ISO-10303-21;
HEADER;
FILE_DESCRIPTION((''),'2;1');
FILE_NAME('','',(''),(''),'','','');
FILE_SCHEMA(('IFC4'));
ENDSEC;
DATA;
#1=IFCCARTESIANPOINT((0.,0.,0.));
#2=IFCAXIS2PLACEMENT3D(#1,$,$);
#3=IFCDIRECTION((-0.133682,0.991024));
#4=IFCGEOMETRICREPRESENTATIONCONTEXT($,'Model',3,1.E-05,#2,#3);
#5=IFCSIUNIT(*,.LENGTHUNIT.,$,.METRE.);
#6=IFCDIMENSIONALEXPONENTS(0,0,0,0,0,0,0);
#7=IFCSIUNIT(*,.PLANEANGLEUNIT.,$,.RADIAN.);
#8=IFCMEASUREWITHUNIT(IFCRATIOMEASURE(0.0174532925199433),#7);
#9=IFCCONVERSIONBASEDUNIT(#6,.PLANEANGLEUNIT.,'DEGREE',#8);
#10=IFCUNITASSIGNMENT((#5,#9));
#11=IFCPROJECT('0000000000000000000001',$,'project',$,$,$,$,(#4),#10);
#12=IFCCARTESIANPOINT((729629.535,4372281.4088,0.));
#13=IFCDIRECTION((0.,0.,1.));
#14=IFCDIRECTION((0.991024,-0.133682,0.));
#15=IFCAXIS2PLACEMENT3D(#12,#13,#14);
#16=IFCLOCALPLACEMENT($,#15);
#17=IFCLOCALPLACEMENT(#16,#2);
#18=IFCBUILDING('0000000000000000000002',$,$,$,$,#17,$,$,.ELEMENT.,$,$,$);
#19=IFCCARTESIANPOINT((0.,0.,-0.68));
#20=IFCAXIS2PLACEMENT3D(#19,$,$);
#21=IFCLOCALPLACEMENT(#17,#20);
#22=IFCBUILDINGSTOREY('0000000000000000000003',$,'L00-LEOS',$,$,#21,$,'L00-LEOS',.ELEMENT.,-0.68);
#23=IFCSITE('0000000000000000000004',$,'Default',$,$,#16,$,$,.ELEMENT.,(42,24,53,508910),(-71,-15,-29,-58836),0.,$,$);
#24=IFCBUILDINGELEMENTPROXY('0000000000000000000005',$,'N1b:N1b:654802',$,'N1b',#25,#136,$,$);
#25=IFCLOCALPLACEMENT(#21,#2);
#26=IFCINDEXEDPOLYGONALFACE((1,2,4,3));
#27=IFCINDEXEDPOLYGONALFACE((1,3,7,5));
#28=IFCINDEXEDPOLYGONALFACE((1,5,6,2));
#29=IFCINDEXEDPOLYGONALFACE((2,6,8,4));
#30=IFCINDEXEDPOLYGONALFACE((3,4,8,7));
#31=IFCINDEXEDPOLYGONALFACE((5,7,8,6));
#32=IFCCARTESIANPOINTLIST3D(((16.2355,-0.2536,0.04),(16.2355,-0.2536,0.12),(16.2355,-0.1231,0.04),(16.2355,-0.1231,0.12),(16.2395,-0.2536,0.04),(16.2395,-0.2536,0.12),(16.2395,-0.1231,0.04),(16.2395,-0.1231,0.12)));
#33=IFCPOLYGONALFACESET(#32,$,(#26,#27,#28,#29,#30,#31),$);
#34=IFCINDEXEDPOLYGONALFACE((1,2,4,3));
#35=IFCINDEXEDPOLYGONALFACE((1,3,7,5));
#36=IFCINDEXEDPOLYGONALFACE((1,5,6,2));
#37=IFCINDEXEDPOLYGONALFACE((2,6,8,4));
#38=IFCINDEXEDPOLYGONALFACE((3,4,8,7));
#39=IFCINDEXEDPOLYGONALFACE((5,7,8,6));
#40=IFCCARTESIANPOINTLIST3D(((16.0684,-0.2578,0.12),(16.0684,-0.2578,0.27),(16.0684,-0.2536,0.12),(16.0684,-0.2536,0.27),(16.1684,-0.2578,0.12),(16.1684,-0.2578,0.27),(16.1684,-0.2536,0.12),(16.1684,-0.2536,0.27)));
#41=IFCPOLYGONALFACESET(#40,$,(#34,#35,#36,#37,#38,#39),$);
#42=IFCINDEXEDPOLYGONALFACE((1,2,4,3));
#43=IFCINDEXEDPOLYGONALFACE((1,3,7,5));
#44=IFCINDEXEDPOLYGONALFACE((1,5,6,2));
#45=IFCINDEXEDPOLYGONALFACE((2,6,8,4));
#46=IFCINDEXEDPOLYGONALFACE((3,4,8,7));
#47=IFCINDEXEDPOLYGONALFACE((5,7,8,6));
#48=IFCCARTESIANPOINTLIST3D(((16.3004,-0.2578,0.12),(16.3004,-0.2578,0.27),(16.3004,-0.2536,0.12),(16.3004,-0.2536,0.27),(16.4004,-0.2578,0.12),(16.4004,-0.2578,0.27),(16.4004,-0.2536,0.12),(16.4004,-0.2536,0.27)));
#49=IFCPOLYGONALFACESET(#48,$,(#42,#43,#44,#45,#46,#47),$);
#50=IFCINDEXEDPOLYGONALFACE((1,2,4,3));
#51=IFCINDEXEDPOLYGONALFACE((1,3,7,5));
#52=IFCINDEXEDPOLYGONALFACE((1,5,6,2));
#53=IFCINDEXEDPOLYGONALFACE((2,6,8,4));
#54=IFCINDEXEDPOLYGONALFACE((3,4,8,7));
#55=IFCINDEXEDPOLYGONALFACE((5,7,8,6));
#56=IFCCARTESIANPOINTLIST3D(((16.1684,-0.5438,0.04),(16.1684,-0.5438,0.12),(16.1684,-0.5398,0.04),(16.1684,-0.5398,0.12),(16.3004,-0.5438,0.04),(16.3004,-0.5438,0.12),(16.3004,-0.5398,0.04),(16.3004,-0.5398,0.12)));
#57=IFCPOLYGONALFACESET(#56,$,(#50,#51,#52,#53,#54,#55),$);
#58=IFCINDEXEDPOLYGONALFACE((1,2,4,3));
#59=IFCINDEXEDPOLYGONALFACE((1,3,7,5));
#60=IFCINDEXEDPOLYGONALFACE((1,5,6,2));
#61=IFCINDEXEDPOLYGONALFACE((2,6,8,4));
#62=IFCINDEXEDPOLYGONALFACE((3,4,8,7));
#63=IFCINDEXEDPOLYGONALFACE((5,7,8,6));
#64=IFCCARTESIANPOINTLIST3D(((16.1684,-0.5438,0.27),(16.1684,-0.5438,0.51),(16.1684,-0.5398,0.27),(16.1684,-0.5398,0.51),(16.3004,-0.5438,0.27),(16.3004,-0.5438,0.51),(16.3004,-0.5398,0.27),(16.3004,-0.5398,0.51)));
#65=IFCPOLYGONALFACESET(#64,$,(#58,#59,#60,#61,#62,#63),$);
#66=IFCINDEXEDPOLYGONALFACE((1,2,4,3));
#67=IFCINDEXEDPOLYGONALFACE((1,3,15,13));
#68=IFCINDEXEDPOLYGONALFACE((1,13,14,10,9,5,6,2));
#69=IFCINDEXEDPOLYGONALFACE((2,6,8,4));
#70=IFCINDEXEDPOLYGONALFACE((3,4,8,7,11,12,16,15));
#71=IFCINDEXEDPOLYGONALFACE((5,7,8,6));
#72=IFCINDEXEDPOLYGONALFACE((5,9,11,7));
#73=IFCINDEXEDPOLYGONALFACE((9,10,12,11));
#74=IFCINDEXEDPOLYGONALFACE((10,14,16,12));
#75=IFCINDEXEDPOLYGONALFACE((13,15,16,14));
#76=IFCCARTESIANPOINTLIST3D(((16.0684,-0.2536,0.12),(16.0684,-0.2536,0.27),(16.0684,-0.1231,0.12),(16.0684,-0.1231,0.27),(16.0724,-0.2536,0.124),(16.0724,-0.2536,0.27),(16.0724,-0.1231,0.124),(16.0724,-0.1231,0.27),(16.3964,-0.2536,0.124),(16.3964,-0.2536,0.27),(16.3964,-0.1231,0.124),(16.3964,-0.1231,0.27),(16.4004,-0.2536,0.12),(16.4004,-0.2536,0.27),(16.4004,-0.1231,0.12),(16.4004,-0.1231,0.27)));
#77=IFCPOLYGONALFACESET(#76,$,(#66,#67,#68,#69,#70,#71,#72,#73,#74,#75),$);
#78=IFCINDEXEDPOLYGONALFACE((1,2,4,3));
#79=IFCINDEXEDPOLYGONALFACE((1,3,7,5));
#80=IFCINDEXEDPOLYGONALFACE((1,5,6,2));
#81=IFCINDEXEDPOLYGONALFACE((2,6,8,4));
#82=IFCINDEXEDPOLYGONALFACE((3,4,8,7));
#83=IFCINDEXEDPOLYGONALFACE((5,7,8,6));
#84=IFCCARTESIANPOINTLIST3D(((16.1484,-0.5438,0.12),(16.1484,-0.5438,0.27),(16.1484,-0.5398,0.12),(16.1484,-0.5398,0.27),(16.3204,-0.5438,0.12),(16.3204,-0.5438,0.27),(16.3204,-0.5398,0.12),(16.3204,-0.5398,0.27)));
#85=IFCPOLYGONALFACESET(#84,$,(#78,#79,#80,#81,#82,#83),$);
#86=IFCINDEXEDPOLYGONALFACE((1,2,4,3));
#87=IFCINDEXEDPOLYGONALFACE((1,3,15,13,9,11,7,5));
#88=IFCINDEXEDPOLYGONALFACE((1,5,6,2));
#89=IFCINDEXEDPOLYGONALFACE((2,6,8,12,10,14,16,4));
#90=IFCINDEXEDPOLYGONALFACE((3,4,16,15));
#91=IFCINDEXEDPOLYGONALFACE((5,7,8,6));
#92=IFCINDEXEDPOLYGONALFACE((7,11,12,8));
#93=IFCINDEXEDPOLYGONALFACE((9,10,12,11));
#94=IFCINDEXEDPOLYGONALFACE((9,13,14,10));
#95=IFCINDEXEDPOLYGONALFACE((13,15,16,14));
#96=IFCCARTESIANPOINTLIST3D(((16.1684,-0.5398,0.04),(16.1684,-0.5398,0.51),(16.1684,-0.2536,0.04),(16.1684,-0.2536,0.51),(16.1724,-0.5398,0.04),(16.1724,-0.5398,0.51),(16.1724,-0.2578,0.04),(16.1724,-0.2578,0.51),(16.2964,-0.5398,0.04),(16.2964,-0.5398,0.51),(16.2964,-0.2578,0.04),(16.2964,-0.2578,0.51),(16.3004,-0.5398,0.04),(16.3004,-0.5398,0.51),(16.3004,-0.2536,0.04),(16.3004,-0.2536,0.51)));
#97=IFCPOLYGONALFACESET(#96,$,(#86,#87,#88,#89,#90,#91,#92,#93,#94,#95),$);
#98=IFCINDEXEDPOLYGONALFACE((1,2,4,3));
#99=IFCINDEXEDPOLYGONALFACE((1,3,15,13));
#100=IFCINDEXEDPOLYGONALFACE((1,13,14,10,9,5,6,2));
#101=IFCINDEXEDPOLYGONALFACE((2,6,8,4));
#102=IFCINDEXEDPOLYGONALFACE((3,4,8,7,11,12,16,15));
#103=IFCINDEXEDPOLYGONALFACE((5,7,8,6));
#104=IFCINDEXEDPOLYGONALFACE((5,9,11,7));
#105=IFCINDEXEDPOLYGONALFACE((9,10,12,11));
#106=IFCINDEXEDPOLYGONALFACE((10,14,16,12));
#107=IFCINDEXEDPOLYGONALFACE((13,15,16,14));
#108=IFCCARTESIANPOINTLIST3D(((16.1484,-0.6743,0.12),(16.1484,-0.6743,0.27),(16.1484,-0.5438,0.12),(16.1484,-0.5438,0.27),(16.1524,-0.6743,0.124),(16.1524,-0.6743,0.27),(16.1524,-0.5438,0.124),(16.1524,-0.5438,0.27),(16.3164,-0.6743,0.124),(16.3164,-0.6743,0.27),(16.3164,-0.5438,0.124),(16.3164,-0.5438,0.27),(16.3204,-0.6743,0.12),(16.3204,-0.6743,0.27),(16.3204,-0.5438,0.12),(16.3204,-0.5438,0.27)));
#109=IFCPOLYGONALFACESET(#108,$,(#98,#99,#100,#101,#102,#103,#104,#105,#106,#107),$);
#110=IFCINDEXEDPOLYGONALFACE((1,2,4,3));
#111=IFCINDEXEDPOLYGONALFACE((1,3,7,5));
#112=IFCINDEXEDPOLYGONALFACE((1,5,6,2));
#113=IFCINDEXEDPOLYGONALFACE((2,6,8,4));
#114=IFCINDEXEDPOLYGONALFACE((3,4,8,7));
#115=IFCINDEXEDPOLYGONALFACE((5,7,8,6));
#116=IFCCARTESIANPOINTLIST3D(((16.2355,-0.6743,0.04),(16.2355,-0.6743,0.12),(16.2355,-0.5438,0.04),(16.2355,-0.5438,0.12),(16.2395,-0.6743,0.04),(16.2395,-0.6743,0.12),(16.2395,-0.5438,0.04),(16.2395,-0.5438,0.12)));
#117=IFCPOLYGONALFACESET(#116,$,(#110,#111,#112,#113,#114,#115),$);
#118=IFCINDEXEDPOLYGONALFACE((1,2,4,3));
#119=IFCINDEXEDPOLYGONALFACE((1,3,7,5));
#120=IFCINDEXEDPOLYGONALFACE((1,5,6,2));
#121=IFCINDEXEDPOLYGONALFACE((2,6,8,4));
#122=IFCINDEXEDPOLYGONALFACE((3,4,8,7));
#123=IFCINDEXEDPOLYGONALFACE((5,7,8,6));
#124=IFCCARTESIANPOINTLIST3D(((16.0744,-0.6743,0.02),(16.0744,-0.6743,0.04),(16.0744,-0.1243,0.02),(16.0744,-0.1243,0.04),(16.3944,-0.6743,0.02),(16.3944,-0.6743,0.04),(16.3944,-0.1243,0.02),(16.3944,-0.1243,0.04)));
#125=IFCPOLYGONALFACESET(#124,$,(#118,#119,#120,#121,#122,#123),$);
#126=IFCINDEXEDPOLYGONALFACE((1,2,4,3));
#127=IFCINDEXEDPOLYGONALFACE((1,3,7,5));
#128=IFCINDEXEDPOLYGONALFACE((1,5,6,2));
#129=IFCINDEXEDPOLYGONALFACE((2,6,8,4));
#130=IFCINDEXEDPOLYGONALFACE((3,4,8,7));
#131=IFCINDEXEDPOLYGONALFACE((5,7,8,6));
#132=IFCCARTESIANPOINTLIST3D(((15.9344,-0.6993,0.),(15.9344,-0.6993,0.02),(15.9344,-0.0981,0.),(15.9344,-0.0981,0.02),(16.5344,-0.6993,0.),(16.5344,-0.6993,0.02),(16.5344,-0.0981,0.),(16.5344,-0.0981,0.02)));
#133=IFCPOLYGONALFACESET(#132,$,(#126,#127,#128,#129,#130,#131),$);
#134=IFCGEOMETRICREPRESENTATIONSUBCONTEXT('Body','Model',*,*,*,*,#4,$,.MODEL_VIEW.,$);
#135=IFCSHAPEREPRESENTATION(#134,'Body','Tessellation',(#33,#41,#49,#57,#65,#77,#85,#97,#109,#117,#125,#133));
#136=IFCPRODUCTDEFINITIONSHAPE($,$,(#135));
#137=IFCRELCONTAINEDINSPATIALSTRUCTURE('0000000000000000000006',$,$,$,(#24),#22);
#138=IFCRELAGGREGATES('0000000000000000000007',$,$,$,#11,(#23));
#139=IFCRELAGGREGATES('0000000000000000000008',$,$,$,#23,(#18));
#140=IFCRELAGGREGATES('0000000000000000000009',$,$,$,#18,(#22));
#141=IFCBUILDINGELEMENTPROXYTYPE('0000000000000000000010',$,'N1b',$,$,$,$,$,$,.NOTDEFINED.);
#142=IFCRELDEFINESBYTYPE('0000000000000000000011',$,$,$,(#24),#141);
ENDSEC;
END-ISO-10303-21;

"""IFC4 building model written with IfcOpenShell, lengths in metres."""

from ifc_helpers import new_model, entity, si_unit, converted_unit, direction, frame, frame_2d, origin, origin_2d_with_axis, place, context, subcontext, project, spatial, polyline, rectangle, outline, extrude, source, transform, mapped, type_object, type_shapes, element, save


model = new_model("IFC4")

# Units and contexts
model_context = context("Model", 3, precision=1e-05, world=origin(), true_north=direction((-0.133682, 0.991024)))
body_context = subcontext(model_context, "Body", "Model", "MODEL_VIEW")
ifc_project = project(units=[si_unit("LENGTHUNIT", "METRE"), converted_unit("PLANEANGLEUNIT", "DEGREE", entity("IfcRatioMeasure", 0.0174532925199433), si_unit("PLANEANGLEUNIT", "RADIAN"), dimensions=[0, 0, 0, 0, 0, 0, 0])], contexts=[model_context])

# Site, building, storey
site_placement = place(None, frame((729629.535, 4372281.4088, 0.0), z_axis=(0.0, 0.0, 1.0), x_axis=(0.991024, -0.133682, 0.0)))
site = spatial("IfcSite", under=ifc_project, at=site_placement, Name="Default", CompositionType="ELEMENT", RefLatitude=(42, 24, 53, 508910), RefLongitude=(-71, -15, -29, -58836), RefElevation=0.0)
building_placement = place(site_placement, origin())
building = spatial("IfcBuilding", under=site, at=building_placement, CompositionType="ELEMENT")
storey_placement = place(building_placement, frame((0.0, 0.0, -0.68)))
storey = spatial("IfcBuildingStorey", under=building, at=storey_placement, Name="L00-LEOS", LongName="L00-LEOS", CompositionType="ELEMENT", Elevation=-0.68)

# Building element proxy
building_element_proxy_type_1 = type_object("IfcBuildingElementProxyType", Name="N1b")
shared_shape_1 = source(origin(), body_context, "Body", "SweptSolid", [
    extrude(rectangle(XDim=0.004, YDim=0.1305, at=origin_2d_with_axis()), frame((0.2103, 0.0, 0.04), z_axis=(0.0, 0.0, 1.0), x_axis=(0.0, -1.0, 0.0)), (0.0, 0.0, 1.0), 0.08),
    extrude(rectangle(XDim=0.1, YDim=0.0042, at=frame_2d((0.0, 0.0), x_axis=(1.0, 0.0))), frame((0.143, 0.1191, 0.12), z_axis=(0.0, 0.0, 1.0), x_axis=(0.0, 1.0, 0.0)), (0.0, 0.0, 1.0), 0.15),
    extrude(rectangle(XDim=0.1, YDim=0.0042, at=origin_2d_with_axis()), frame((0.143, -0.1129, 0.12), z_axis=(0.0, 0.0, 1.0), x_axis=(0.0, 1.0, 0.0)), (0.0, 0.0, 1.0), 0.15),
    extrude(rectangle(XDim=0.132, YDim=0.004, at=frame_2d((0.0, 0.0), x_axis=(1.0, 0.0))), frame((-0.1431, 0.0031, 0.04), z_axis=(0.0, 0.0, 1.0), x_axis=(0.0, 1.0, 0.0)), (0.0, 0.0, 1.0), 0.08),
    extrude(rectangle(XDim=0.132, YDim=0.004, at=frame_2d((0.0, 0.0), x_axis=(1.0, 0.0))), frame((-0.1431, 0.0031, 0.27), z_axis=(0.0, 0.0, 1.0), x_axis=(0.0, 1.0, 0.0)), (0.0, 0.0, 1.0), 0.24),
    extrude(outline(polyline([(-0.076, -0.166), (0.074, -0.166), (0.074, -0.162), (-0.072, -0.162), (-0.072, 0.162), (0.074, 0.162), (0.074, 0.166), (-0.076, 0.166), (-0.076, -0.166)])), frame((0.1451, 0.0031, 0.196), z_axis=(1.0, 0.0, 0.0), x_axis=(0.0, 0.0, 1.0)), (0.0, 0.0, 1.0), 0.1305),
    extrude(rectangle(XDim=0.172, YDim=0.004, at=frame_2d((0.0, 0.0), x_axis=(1.0, 0.0))), frame((-0.1431, 0.0031, 0.12), z_axis=(0.0, 0.0, 1.0), x_axis=(0.0, 1.0, 0.0)), (0.0, 0.0, 1.0), 0.15),
    extrude(outline(polyline([(-0.1441, -0.066), (0.142, -0.066), (0.142, -0.062), (-0.14, -0.062), (-0.14, 0.062), (0.142, 0.062), (0.142, 0.066), (-0.1441, 0.066), (-0.1441, -0.066)])), frame((0.001, 0.0031, 0.04), z_axis=(0.0, 0.0, 1.0), x_axis=(-1.0, 0.0, 0.0)), (0.0, 0.0, 1.0), 0.47),
    extrude(outline(polyline([(-0.076, -0.086), (0.074, -0.086), (0.074, -0.082), (-0.072, -0.082), (-0.072, 0.082), (0.074, 0.082), (0.074, 0.086), (-0.076, 0.086), (-0.076, -0.086)])), frame((-0.2756, 0.0031, 0.196), z_axis=(1.0, 0.0, 0.0), x_axis=(0.0, 0.0, 1.0)), (0.0, 0.0, 1.0), 0.1305),
    extrude(rectangle(XDim=0.004, YDim=0.1305, at=origin_2d_with_axis()), frame((-0.2103, 0.0, 0.04), z_axis=(0.0, 0.0, 1.0), x_axis=(0.0, -1.0, 0.0)), (0.0, 0.0, 1.0), 0.08),
    extrude(rectangle(XDim=0.55, YDim=0.32, at=frame_2d((0.0, 0.0), x_axis=(1.0, 0.0))), frame((-0.0006, 0.0031, 0.02), z_axis=(0.0, 0.0, 1.0), x_axis=(-1.0, 0.0, 0.0)), (0.0, 0.0, 1.0), 0.02),
    extrude(rectangle(XDim=0.6012, YDim=0.6, at=frame_2d((0.0, 0.0), x_axis=(1.0, 0.0))), frame((0.0, 0.0031, 0.0), z_axis=(0.0, 0.0, 1.0), x_axis=(-1.0, 0.0, 0.0)), (0.0, 0.0, 1.0), 0.02),
])
type_shapes(building_element_proxy_type_1, [shared_shape_1])
for number, where, z_axis, x_axis, name in (
    (1, (16.2375, -0.3987, 0.0), (0.0, 0.0, 1.0), (0.0, 1.0, 0.0), "N1b:N1b:654802"),
):
    element("IfcBuildingElementProxy", number, at=place(storey_placement, frame(where, z_axis=z_axis, x_axis=x_axis)), inside=storey, type_object=building_element_proxy_type_1, Name=name, ObjectType="N1b", context=body_context, shape_type="MappedRepresentation", body=[
        mapped(shared_shape_1, transform((0.0, 0.0, 0.0), scale=1.0)),
    ])

save(model, "model.ifc")
